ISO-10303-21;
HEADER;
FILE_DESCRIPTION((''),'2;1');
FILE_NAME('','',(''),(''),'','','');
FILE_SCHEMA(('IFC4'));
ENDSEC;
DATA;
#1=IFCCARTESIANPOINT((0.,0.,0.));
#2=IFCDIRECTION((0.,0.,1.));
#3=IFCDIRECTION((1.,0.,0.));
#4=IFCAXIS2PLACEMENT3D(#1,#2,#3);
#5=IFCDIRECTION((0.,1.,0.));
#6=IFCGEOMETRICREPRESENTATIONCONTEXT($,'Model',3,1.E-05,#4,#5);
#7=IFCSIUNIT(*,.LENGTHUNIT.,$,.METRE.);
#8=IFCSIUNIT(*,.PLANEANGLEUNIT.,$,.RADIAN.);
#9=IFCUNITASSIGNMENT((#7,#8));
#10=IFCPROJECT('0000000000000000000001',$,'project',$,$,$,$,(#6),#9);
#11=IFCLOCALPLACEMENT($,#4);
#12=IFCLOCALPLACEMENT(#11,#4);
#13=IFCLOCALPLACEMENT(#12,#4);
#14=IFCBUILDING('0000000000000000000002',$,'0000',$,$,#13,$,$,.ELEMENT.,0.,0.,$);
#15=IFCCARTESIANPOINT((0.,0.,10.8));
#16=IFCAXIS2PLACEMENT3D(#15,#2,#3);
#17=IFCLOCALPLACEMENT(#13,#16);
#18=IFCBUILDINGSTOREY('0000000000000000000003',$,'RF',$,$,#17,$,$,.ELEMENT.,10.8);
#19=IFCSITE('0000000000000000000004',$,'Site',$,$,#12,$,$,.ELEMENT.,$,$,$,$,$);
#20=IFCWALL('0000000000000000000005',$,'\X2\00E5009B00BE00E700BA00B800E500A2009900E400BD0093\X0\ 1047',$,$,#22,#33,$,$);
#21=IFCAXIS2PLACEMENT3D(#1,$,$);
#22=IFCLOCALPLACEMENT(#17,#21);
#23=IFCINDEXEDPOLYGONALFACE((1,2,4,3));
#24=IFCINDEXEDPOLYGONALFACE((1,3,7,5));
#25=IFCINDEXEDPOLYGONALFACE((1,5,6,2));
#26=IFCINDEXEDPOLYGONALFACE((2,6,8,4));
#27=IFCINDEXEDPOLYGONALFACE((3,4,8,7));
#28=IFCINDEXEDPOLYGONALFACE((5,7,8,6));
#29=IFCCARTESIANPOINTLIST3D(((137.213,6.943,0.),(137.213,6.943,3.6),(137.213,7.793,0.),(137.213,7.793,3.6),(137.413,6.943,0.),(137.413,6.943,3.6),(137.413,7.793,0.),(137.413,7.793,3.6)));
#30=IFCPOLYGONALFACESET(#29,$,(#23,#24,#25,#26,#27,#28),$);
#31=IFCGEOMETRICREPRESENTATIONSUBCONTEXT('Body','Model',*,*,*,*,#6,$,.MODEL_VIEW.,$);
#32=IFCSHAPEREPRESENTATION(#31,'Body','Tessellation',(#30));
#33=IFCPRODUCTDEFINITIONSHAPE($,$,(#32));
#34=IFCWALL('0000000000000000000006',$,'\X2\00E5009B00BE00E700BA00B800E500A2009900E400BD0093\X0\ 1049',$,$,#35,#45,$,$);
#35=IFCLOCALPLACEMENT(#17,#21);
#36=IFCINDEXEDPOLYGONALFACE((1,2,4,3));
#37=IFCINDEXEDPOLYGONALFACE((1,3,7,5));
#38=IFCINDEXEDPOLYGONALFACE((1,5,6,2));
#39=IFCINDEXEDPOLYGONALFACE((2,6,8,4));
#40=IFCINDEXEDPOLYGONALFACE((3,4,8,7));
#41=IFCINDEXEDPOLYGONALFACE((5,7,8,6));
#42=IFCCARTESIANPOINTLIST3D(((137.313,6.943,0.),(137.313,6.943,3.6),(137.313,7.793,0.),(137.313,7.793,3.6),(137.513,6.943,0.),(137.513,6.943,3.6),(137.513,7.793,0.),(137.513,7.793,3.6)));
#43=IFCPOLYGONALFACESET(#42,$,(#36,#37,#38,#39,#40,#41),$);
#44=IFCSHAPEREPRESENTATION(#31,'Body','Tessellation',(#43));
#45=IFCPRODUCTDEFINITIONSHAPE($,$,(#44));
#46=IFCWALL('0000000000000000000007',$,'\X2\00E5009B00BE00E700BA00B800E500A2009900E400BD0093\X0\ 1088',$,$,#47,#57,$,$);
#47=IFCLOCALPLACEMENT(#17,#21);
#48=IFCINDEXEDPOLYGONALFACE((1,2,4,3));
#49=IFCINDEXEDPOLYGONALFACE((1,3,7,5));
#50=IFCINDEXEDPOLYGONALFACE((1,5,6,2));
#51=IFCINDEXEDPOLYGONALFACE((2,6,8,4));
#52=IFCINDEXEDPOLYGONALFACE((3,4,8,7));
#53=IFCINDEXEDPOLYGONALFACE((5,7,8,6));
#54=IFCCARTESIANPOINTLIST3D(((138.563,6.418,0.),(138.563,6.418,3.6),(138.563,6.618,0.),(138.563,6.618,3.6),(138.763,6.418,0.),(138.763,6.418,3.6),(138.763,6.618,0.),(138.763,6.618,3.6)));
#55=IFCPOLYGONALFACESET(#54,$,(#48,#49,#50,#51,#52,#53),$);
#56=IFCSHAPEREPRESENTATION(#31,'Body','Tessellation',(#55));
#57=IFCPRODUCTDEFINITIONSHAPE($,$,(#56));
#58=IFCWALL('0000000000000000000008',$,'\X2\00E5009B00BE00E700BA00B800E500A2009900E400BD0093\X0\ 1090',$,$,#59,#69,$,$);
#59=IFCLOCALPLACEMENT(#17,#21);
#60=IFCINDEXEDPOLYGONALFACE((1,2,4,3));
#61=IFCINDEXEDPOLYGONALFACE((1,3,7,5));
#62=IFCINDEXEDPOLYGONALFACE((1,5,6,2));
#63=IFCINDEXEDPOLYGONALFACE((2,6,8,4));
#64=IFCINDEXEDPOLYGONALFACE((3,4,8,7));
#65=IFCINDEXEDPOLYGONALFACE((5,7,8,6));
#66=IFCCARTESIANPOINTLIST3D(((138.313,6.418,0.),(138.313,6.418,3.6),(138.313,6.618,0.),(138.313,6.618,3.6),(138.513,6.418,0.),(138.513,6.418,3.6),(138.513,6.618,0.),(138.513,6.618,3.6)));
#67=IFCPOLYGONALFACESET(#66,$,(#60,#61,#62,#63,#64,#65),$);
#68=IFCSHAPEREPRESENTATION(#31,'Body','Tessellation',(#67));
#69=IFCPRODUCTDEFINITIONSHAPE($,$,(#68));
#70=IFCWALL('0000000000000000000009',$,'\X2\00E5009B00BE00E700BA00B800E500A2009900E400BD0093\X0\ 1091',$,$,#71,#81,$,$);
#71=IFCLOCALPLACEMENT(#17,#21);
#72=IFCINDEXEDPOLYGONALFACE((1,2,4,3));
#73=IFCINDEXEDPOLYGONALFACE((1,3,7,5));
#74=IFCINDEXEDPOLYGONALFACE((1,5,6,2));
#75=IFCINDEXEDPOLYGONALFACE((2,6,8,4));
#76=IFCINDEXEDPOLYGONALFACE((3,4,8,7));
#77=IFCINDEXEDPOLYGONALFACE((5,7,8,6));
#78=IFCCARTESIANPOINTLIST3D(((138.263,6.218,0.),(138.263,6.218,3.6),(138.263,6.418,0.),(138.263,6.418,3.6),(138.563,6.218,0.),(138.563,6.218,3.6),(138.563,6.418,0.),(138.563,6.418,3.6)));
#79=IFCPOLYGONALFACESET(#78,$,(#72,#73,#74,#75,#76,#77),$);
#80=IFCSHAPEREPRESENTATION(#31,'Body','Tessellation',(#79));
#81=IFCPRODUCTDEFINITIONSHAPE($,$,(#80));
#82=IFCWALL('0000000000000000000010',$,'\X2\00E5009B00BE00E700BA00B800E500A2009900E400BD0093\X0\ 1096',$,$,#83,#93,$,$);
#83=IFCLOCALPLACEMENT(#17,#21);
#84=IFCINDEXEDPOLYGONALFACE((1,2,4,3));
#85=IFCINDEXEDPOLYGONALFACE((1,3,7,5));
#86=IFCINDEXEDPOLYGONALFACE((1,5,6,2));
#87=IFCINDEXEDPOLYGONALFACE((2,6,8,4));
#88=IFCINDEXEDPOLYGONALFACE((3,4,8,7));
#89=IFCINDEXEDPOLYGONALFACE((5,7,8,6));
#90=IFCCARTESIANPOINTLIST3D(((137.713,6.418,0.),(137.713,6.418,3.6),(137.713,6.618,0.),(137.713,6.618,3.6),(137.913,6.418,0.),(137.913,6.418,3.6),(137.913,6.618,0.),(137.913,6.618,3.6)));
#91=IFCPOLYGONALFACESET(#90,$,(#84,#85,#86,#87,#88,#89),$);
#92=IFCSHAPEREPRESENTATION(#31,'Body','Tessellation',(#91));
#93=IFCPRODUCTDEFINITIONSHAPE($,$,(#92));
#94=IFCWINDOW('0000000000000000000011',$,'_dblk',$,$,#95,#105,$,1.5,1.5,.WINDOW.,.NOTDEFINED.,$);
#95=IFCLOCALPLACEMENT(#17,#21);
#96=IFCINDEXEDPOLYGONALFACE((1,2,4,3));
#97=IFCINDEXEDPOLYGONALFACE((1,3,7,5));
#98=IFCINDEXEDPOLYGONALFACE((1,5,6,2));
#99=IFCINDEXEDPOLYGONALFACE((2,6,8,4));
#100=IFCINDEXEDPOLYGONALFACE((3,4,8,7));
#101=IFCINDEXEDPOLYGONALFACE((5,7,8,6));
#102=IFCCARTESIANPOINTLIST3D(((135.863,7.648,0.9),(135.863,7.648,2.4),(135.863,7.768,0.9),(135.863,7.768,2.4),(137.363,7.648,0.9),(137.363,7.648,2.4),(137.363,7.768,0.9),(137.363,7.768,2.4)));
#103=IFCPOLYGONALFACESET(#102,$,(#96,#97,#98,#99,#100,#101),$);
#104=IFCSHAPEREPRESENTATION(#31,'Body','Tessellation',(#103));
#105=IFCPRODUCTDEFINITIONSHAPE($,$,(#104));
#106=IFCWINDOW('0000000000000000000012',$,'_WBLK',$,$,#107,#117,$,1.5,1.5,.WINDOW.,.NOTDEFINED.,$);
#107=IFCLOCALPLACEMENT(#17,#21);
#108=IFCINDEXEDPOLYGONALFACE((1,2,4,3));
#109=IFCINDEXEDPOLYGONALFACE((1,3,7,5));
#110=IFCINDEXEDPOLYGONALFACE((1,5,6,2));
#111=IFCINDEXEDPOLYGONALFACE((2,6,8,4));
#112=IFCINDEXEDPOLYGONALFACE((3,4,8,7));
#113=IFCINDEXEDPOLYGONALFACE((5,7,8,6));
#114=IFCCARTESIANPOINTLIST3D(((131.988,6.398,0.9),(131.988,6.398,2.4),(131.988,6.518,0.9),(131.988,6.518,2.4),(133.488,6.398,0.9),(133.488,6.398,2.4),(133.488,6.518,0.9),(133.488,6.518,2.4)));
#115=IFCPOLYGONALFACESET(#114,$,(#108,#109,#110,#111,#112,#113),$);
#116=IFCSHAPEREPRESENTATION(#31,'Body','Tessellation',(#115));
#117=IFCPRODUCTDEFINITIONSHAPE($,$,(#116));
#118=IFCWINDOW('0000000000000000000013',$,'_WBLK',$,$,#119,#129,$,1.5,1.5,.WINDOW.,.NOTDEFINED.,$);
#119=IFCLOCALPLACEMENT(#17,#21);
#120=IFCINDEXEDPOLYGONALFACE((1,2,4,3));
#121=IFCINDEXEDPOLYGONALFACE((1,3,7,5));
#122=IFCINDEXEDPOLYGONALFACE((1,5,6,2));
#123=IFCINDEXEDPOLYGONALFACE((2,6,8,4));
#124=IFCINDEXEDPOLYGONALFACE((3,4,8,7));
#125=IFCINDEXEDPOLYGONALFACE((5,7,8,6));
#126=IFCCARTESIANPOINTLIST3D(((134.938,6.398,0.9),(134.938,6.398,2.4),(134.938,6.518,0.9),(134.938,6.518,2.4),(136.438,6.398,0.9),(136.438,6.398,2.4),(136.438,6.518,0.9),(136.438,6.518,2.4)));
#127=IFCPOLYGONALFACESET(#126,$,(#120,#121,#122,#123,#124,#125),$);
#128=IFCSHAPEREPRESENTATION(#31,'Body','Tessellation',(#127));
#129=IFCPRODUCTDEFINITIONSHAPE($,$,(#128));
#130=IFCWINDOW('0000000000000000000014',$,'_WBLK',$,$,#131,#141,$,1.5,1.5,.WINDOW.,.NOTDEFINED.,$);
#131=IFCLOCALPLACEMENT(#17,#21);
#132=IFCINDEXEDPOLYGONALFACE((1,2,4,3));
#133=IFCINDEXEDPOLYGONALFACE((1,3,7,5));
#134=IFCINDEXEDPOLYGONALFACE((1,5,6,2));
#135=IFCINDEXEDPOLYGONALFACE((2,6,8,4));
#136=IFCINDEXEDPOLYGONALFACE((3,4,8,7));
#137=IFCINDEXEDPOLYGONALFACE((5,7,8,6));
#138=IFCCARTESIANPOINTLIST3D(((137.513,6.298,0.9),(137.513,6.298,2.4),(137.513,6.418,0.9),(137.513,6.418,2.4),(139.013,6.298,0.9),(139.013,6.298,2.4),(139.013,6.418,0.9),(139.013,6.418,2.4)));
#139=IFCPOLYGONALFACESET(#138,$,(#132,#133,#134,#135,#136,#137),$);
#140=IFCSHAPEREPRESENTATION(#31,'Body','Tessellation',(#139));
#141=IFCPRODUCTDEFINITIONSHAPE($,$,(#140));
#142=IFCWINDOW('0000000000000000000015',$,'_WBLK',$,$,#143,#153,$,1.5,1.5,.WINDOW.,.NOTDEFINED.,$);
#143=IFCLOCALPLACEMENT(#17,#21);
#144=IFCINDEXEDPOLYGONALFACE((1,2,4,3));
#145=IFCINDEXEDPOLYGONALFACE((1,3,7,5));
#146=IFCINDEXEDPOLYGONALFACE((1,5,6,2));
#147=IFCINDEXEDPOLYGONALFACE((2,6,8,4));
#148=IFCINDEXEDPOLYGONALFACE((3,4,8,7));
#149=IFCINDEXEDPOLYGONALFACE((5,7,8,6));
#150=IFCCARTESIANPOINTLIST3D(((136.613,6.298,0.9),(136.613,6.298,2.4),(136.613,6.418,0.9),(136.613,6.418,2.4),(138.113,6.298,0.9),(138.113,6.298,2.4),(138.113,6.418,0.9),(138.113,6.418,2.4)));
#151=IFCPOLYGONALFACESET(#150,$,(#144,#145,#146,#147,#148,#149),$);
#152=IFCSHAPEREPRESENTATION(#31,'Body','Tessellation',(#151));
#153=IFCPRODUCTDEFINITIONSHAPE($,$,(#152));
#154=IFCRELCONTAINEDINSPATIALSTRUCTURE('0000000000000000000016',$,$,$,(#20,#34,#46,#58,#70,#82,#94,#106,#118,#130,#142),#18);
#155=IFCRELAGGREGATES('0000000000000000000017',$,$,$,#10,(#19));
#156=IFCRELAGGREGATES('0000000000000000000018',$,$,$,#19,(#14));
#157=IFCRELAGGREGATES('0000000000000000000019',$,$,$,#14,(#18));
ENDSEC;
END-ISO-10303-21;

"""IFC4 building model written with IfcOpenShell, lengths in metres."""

from ifc_helpers import new_model, si_unit, direction, frame, frame_2d, origin_with_axes, place, context, subcontext, project, spatial, rectangle, extrude, element, save


model = new_model("IFC4")

# Units and contexts
model_context = context("Model", 3, precision=1e-05, world=origin_with_axes(), true_north=direction((0.0, 1.0, 0.0)))
body_context = subcontext(model_context, "Body", "Model", "MODEL_VIEW")
ifc_project = project(units=[si_unit("LENGTHUNIT", "METRE"), si_unit("PLANEANGLEUNIT", "RADIAN")], contexts=[model_context])

# Site, building, storey
placement = place(None, origin_with_axes())
site_placement = place(placement, origin_with_axes())
site = spatial("IfcSite", under=ifc_project, at=site_placement, Name="Site", CompositionType="ELEMENT")
building_placement = place(site_placement, origin_with_axes())
building = spatial("IfcBuilding", under=site, at=building_placement, Name="0000", CompositionType="ELEMENT", ElevationOfRefHeight=0.0, ElevationOfTerrain=0.0)
storey_placement = place(building_placement, frame((0.0, 0.0, 10.8), z_axis=(0.0, 0.0, 1.0), x_axis=(1.0, 0.0, 0.0)))
storey = spatial("IfcBuildingStorey", under=building, at=storey_placement, Name="RF", CompositionType="ELEMENT", Elevation=10.8)

# Walls
for number, where, z_axis, x_axis, name in (
    (1, (137.313, 7.368, 0.0), (0.0, 0.0, 1.0), (0.0, -1.0, 0.0), "å\u009b¾çº¸å¢\u0099ä½\u0093 1047"),
    (2, (137.413, 7.368, 0.0), (0.0, 0.0, 1.0), (0.0, -1.0, 0.0), "å\u009b¾çº¸å¢\u0099ä½\u0093 1049"),
):
    element("IfcWall", number, at=place(storey_placement, frame(where, z_axis=z_axis, x_axis=x_axis)), inside=storey, Name=name, context=body_context, shape_type="SweptSolid", body=[
        extrude(rectangle(XDim=0.85, YDim=0.2, at=frame_2d((0.0, 0.0), x_axis=(1.0, 0.0, 0.0))), frame((0.0, 0.0, 0.0), z_axis=(0.0, 0.0, 1.0)), (0.0, 0.0, 1.0), 3.6),
    ])
for number, where, z_axis, x_axis, name in (
    (3, (138.663, 6.518, 0.0), (0.0, 0.0, 1.0), (1.0, 0.0, 0.0), "å\u009b¾çº¸å¢\u0099ä½\u0093 1088"),
    (4, (138.413, 6.518, 0.0), (0.0, 0.0, 1.0), (1.0, 0.0, 0.0), "å\u009b¾çº¸å¢\u0099ä½\u0093 1090"),
):
    element("IfcWall", number, at=place(storey_placement, frame(where, z_axis=z_axis, x_axis=x_axis)), inside=storey, Name=name, context=body_context, shape_type="SweptSolid", body=[
        extrude(rectangle(XDim=0.2, YDim=0.2, at=frame_2d((0.0, 0.0), x_axis=(1.0, 0.0, 0.0))), frame((0.0, 0.0, 0.0), z_axis=(0.0, 0.0, 1.0)), (0.0, 0.0, 1.0), 3.6),
    ])
wall_1_placement = place(storey_placement, frame((138.413, 6.318, 0.0), z_axis=(0.0, 0.0, 1.0), x_axis=(1.0, 0.0, 0.0)))
element("IfcWall", 5, at=wall_1_placement, inside=storey, Name="å\u009b¾çº¸å¢\u0099ä½\u0093 1091", context=body_context, shape_type="SweptSolid", body=[
    extrude(rectangle(XDim=0.3, YDim=0.2, at=frame_2d((0.0, 0.0), x_axis=(1.0, 0.0, 0.0))), frame((0.0, 0.0, 0.0), z_axis=(0.0, 0.0, 1.0)), (0.0, 0.0, 1.0), 3.6),
])
for number, where, z_axis, x_axis, name in (
    (6, (137.813, 6.518, 0.0), (0.0, 0.0, 1.0), (0.0, -1.0, 0.0), "å\u009b¾çº¸å¢\u0099ä½\u0093 1096"),
):
    element("IfcWall", number, at=place(storey_placement, frame(where, z_axis=z_axis, x_axis=x_axis)), inside=storey, Name=name, context=body_context, shape_type="SweptSolid", body=[
        extrude(rectangle(XDim=0.2, YDim=0.2, at=frame_2d((0.0, 0.0), x_axis=(1.0, 0.0, 0.0))), frame((0.0, 0.0, 0.0), z_axis=(0.0, 0.0, 1.0)), (0.0, 0.0, 1.0), 3.6),
    ])

# Windows
for number, where, z_axis, x_axis, name in (
    (7, (136.613, 7.708, 0.9), (0.0, 0.0, 1.0), (1.0, 0.0, 0.0), "_dblk"),
    (8, (132.738, 6.458, 0.9), (0.0, 0.0, 1.0), (1.0, 0.0, 0.0), "_WBLK"),
    (9, (135.688, 6.458, 0.9), (0.0, 0.0, 1.0), (1.0, 0.0, 0.0), "_WBLK"),
    (10, (138.263, 6.358, 0.9), (0.0, 0.0, 1.0), (1.0, 0.0, 0.0), "_WBLK"),
    (11, (137.363, 6.358, 0.9), (0.0, 0.0, 1.0), (1.0, 0.0, 0.0), "_WBLK"),
):
    element("IfcWindow", number, at=place(storey_placement, frame(where, z_axis=z_axis, x_axis=x_axis)), inside=storey, Name=name, OverallHeight=1.5, OverallWidth=1.5, PartitioningType="NOTDEFINED", PredefinedType="WINDOW", context=body_context, shape_type="SweptSolid", body=[
        extrude(rectangle(XDim=1.5, YDim=0.12, at=frame_2d((0.0, 0.0), x_axis=(1.0, 0.0, 0.0))), frame((0.0, 0.0, 0.0), z_axis=(0.0, 0.0, 1.0)), (0.0, 0.0, 1.0), 1.5),
    ])

save(model, "model.ifc")
